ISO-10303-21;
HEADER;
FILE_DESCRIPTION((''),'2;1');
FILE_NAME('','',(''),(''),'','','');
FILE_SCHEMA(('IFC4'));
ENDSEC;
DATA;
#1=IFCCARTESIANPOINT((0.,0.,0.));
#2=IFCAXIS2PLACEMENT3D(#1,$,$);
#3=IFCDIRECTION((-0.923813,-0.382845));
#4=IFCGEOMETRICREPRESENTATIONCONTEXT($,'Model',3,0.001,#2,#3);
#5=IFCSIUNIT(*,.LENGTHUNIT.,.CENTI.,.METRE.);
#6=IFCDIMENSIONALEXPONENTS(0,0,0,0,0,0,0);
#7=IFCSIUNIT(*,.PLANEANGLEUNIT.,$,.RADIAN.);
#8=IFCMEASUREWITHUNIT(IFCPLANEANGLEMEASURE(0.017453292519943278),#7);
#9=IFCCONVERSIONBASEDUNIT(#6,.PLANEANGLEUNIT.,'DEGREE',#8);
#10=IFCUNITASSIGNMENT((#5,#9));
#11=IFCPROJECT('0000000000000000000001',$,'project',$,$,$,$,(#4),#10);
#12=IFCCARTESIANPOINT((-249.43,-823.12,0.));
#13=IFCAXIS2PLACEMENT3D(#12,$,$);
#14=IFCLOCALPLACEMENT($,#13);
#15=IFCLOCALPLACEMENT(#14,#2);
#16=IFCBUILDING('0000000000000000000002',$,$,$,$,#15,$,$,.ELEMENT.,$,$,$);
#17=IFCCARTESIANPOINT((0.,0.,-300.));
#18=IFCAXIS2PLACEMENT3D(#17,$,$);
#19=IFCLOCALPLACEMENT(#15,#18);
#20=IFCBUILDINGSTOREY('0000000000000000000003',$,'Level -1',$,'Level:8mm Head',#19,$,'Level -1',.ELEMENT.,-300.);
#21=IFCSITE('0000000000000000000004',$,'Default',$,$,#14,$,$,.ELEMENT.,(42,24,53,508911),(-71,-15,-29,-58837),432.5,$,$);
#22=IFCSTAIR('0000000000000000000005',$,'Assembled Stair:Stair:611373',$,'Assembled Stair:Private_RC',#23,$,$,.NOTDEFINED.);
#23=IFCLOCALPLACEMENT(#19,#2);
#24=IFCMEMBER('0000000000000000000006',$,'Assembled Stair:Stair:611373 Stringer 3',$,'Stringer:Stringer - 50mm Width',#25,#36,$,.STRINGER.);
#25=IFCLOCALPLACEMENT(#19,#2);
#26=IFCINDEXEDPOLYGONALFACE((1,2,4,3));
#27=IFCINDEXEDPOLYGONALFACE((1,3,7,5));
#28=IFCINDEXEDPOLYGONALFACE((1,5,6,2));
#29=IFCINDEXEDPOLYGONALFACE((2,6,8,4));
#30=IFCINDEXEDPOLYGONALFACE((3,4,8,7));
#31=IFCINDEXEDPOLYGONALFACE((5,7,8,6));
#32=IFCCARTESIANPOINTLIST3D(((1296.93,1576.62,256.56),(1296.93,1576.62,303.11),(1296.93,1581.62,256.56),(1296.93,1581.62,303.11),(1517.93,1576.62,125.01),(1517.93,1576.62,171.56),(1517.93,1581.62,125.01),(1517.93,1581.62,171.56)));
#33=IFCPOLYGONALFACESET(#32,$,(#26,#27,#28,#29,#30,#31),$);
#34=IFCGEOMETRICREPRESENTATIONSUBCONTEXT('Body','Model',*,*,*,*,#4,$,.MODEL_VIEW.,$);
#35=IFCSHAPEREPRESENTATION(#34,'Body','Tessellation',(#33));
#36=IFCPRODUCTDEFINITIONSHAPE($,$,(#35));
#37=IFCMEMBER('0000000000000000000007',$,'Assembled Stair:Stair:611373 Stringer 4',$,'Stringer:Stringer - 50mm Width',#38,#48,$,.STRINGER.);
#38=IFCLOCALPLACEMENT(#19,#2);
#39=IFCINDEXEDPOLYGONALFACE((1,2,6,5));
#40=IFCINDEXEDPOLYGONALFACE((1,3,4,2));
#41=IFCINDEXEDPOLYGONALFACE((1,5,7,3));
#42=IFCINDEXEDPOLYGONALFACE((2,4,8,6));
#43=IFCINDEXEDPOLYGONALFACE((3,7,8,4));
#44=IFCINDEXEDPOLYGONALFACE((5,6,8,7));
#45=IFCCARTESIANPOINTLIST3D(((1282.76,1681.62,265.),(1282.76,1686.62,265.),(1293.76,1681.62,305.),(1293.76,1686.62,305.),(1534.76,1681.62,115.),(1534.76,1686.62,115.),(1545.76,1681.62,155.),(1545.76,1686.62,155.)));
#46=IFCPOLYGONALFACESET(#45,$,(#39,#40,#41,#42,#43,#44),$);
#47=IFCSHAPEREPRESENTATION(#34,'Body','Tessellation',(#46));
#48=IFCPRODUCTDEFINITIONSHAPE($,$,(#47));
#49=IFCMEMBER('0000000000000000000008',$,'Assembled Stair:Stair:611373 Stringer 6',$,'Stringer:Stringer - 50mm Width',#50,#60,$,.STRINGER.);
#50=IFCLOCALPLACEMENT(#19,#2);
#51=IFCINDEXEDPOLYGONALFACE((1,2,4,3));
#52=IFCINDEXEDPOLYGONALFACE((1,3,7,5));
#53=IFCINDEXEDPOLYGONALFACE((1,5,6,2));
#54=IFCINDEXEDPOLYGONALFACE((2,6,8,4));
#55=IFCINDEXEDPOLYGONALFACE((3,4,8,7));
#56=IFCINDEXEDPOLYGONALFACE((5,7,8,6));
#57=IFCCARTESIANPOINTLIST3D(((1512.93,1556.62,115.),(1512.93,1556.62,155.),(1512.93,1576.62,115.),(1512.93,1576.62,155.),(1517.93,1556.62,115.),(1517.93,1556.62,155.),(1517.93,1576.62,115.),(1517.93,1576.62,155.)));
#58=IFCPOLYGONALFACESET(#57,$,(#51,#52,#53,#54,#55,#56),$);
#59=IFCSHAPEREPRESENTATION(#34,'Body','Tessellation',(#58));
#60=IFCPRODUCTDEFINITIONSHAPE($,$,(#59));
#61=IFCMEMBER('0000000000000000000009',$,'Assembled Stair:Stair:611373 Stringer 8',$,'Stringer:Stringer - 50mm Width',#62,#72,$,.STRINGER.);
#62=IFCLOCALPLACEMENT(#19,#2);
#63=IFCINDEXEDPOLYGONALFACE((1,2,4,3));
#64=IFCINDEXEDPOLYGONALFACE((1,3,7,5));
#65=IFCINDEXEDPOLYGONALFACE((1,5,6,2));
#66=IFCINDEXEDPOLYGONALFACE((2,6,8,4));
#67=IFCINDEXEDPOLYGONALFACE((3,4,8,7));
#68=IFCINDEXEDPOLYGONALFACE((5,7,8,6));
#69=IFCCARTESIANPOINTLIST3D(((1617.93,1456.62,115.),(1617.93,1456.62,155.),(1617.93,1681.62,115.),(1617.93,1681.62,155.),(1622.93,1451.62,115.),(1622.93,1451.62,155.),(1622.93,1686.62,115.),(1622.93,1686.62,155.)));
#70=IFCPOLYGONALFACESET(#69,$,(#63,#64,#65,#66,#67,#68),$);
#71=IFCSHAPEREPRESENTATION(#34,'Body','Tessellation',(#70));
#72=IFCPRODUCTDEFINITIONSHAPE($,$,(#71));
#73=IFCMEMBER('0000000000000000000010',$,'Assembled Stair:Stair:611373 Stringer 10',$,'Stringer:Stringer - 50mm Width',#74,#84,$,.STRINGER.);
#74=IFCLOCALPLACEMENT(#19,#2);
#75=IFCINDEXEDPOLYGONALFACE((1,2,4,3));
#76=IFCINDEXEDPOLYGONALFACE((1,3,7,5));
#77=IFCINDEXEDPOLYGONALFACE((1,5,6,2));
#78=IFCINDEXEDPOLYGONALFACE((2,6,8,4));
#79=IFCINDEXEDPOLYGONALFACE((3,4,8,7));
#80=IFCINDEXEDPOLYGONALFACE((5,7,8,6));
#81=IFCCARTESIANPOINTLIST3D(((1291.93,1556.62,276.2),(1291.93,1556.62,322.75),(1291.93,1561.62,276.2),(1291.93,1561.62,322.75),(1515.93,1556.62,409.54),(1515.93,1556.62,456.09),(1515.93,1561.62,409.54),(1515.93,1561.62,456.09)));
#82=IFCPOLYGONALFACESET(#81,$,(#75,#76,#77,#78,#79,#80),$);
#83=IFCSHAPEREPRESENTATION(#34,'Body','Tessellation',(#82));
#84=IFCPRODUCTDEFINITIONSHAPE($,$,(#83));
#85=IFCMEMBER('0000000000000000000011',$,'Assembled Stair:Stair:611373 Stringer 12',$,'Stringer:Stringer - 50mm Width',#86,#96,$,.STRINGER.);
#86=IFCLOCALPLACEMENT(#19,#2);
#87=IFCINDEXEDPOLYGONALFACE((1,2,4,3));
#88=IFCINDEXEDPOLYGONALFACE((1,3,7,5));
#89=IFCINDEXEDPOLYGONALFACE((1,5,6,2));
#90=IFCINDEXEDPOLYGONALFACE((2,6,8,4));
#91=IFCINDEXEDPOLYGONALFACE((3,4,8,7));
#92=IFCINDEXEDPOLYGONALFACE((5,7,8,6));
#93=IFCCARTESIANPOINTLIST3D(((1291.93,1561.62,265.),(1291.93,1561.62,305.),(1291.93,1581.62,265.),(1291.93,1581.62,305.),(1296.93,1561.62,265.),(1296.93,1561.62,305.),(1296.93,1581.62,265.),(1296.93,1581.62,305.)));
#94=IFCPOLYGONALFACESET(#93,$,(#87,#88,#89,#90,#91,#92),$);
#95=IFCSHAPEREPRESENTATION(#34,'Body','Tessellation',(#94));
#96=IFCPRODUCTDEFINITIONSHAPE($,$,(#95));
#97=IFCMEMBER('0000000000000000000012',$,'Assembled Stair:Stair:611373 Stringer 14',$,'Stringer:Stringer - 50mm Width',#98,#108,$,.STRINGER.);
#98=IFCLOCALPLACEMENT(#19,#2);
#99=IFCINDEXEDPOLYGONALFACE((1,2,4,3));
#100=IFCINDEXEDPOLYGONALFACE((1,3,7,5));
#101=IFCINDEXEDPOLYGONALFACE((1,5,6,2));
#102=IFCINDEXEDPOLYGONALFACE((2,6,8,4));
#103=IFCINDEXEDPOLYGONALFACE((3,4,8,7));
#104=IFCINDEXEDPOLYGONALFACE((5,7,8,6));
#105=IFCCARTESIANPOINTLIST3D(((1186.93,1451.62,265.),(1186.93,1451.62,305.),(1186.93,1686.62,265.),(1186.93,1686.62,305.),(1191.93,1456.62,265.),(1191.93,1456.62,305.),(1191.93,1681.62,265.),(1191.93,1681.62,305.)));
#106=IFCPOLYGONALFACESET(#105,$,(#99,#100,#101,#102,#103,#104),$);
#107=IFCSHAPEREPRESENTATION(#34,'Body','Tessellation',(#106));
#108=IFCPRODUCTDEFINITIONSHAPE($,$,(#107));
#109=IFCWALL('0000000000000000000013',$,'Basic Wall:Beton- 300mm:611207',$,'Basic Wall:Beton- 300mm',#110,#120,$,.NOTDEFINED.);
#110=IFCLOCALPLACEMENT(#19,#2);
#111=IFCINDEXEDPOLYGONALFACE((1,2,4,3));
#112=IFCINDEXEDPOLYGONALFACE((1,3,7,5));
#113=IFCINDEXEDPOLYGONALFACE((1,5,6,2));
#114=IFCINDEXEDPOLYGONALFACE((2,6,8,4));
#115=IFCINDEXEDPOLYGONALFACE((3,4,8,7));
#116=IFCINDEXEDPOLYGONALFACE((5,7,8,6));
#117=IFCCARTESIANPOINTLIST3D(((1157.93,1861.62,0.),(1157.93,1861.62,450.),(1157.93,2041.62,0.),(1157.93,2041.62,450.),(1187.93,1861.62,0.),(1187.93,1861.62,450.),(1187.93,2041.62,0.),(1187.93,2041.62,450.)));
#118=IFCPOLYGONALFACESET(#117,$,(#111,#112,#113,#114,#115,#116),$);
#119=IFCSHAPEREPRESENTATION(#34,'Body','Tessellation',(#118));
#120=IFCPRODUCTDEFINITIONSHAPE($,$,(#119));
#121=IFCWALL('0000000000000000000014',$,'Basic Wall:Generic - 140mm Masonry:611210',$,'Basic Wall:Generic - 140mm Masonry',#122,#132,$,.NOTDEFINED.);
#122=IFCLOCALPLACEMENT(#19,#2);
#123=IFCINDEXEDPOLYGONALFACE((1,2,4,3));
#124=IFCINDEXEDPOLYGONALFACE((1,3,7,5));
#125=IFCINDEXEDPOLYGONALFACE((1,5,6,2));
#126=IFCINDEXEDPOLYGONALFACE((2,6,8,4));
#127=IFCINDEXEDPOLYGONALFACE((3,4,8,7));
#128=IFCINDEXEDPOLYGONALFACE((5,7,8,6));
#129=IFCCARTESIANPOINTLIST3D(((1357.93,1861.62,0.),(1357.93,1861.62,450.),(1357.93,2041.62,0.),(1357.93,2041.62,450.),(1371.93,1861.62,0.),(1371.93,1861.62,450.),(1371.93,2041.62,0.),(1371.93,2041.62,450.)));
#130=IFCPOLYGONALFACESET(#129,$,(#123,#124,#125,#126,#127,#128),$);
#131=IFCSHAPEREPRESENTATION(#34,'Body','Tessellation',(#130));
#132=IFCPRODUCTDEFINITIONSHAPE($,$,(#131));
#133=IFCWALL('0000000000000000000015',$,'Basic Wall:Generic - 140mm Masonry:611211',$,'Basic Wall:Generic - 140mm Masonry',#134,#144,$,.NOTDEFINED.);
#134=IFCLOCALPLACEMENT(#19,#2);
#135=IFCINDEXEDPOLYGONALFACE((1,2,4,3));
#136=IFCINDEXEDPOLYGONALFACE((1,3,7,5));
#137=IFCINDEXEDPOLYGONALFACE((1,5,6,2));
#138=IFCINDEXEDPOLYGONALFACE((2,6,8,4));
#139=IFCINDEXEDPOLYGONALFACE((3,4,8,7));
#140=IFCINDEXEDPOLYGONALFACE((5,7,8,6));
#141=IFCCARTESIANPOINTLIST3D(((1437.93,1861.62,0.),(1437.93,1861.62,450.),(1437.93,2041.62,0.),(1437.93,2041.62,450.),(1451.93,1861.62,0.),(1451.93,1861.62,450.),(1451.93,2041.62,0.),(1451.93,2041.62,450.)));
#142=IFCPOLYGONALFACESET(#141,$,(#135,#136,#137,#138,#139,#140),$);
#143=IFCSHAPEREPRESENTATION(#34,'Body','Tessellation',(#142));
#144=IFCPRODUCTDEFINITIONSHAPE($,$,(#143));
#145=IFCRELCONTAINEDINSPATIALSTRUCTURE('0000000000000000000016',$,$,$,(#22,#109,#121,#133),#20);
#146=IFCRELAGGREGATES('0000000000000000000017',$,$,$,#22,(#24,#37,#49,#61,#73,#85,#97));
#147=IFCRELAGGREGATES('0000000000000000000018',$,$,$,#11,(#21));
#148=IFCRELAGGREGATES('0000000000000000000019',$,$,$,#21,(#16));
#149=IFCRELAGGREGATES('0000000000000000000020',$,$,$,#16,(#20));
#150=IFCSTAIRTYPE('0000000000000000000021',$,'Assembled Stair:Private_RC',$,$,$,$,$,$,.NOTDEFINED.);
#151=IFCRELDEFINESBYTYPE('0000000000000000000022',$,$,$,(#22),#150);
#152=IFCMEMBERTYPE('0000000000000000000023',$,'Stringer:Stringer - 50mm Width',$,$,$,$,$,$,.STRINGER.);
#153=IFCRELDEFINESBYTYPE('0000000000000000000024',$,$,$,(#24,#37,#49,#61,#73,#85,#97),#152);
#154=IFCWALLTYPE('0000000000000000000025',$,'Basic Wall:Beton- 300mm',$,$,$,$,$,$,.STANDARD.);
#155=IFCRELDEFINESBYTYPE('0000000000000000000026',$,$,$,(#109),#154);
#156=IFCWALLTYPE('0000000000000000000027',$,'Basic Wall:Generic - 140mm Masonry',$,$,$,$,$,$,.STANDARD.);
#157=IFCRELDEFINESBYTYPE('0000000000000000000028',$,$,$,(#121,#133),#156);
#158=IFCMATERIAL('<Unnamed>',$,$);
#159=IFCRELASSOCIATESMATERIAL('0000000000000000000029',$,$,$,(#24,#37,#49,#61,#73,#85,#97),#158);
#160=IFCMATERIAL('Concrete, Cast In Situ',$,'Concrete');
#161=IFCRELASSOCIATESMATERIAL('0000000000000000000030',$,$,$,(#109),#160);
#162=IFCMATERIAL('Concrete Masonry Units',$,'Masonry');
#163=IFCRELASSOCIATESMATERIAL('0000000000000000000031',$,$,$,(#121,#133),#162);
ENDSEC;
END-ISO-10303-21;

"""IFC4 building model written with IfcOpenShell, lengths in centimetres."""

from ifc_helpers import new_model, entity, si_unit, converted_unit, direction, frame, origin, place, context, subcontext, project, spatial, indexed_curve, outline, extrude, material, type_object, element, aggregate, save


model = new_model("IFC4")

# Units and contexts
model_context = context("Model", 3, precision=0.001, world=origin(), true_north=direction((-0.923813, -0.382845)))
body_context = subcontext(model_context, "Body", "Model", "MODEL_VIEW")
ifc_project = project(units=[si_unit("LENGTHUNIT", "METRE", prefix="CENTI"), converted_unit("PLANEANGLEUNIT", "DEGREE", entity("IfcPlaneAngleMeasure", 0.017453292519943278), si_unit("PLANEANGLEUNIT", "RADIAN"), dimensions=[0, 0, 0, 0, 0, 0, 0])], contexts=[model_context])

# Site, building, storey
site_placement = place(None, frame((-249.43, -823.12, 0.0)))
site = spatial("IfcSite", under=ifc_project, at=site_placement, Name="Default", CompositionType="ELEMENT", RefLatitude=(42, 24, 53, 508911), RefLongitude=(-71, -15, -29, -58837), RefElevation=432.5)
building_placement = place(site_placement, origin())
building = spatial("IfcBuilding", under=site, at=building_placement, CompositionType="ELEMENT")
storey_placement = place(building_placement, frame((0.0, 0.0, -300.0)))
storey = spatial("IfcBuildingStorey", under=building, at=storey_placement, Name="Level -1", ObjectType="Level:8mm Head", LongName="Level -1", CompositionType="ELEMENT", Elevation=-300.0)

# Stair, members
stair_type = type_object("IfcStairType", Name="Assembled Stair:Private_RC", PredefinedType="NOTDEFINED")
stair_placement = place(storey_placement, origin())
stair = element("IfcStair", 1, at=stair_placement, inside=storey, type_object=stair_type, Name="Assembled Stair:Stair:611373", ObjectType="Assembled Stair:Private_RC", PredefinedType="NOTDEFINED")
ifc_material_1 = material(Name="<Unnamed>")
member_type = type_object("IfcMemberType", Name="Stringer:Stringer - 50mm Width", PredefinedType="STRINGER")
member_1_placement = place(stair_placement, origin())
member_1 = element("IfcMember", 2, at=member_1_placement, type_object=member_type, material=ifc_material_1, Name="Assembled Stair:Stair:611373 Stringer 3", ObjectType="Stringer:Stringer - 50mm Width", PredefinedType="STRINGER", context=body_context, shape_type="SweptSolid", body=[
    extrude(outline(indexed_curve([(-140.5, -20.0), (116.69, -20.0), (140.5, 20.0), (-116.69, 20.0), (-140.5, -20.0)], self_intersect=False)), frame((1407.43, 1576.62, 214.06), z_axis=(0.0, 1.0, 0.0), x_axis=(-0.859293, 0.0, 0.511484)), (0.0, 0.0, 1.0), 5.0),
])
member_2_placement = place(stair_placement, origin())
member_2 = element("IfcMember", 3, at=member_2_placement, type_object=member_type, material=ifc_material_1, Name="Assembled Stair:Stair:611373 Stringer 4", ObjectType="Stringer:Stringer - 50mm Width", PredefinedType="STRINGER", context=body_context, shape_type="SweptSolid", body=[
    extrude(outline(indexed_curve([(-152.13, -20.0), (141.13, -20.0), (152.13, 20.0), (-141.13, 20.0), (-152.13, -20.0)], self_intersect=False)), frame((1414.26, 1681.62, 210.0), z_axis=(0.0, 1.0, 0.0), x_axis=(-0.859293, 0.0, 0.511484)), (0.0, 0.0, 1.0), 5.0),
])
member_3_placement = place(stair_placement, origin())
member_3 = element("IfcMember", 4, at=member_3_placement, type_object=member_type, material=ifc_material_1, Name="Assembled Stair:Stair:611373 Stringer 6", ObjectType="Stringer:Stringer - 50mm Width", PredefinedType="STRINGER", context=body_context, shape_type="SweptSolid", body=[
    extrude(outline(indexed_curve([(-10.0, -2.5), (10.0, -2.5), (10.0, 2.5), (-10.0, 2.5), (-10.0, -2.5)], self_intersect=False)), frame((1515.43, 1566.62, 115.0), z_axis=(0.0, 0.0, 1.0), x_axis=(0.0, -1.0, 0.0)), (0.0, 0.0, 1.0), 40.0),
])
member_4_placement = place(stair_placement, origin())
member_4 = element("IfcMember", 5, at=member_4_placement, type_object=member_type, material=ifc_material_1, Name="Assembled Stair:Stair:611373 Stringer 8", ObjectType="Stringer:Stringer - 50mm Width", PredefinedType="STRINGER", context=body_context, shape_type="SweptSolid", body=[
    extrude(outline(indexed_curve([(-117.5, -2.5), (117.5, -2.5), (112.5, 2.5), (-112.5, 2.5), (-117.5, -2.5)], self_intersect=False)), frame((1620.43, 1569.12, 115.0), z_axis=(0.0, 0.0, 1.0), x_axis=(0.0, 1.0, 0.0)), (0.0, 0.0, 1.0), 40.0),
])
member_5_placement = place(stair_placement, origin())
member_5 = element("IfcMember", 6, at=member_5_placement, type_object=member_type, material=ifc_material_1, Name="Assembled Stair:Stair:611373 Stringer 10", ObjectType="Stringer:Stringer - 50mm Width", PredefinedType="STRINGER", context=body_context, shape_type="SweptSolid", body=[
    extrude(outline(indexed_curve([(-118.43, -20.0), (142.24, -20.0), (118.43, 20.0), (-142.24, 20.0), (-118.43, -20.0)], self_intersect=False)), frame((1403.93, 1556.62, 366.15), z_axis=(0.0, 1.0, 0.0), x_axis=(0.859293, 0.0, 0.511484)), (0.0, 0.0, 1.0), 5.0),
])
member_6_placement = place(stair_placement, origin())
member_6 = element("IfcMember", 7, at=member_6_placement, type_object=member_type, material=ifc_material_1, Name="Assembled Stair:Stair:611373 Stringer 12", ObjectType="Stringer:Stringer - 50mm Width", PredefinedType="STRINGER", context=body_context, shape_type="SweptSolid", body=[
    extrude(outline(indexed_curve([(-10.0, -2.5), (10.0, -2.5), (10.0, 2.5), (-10.0, 2.5), (-10.0, -2.5)], self_intersect=False)), frame((1294.43, 1571.62, 265.0), z_axis=(0.0, 0.0, 1.0), x_axis=(0.0, 1.0, 0.0)), (0.0, 0.0, 1.0), 40.0),
])
member_7_placement = place(stair_placement, origin())
member_7 = element("IfcMember", 8, at=member_7_placement, type_object=member_type, material=ifc_material_1, Name="Assembled Stair:Stair:611373 Stringer 14", ObjectType="Stringer:Stringer - 50mm Width", PredefinedType="STRINGER", context=body_context, shape_type="SweptSolid", body=[
    extrude(outline(indexed_curve([(-117.5, -2.5), (117.5, -2.5), (112.5, 2.5), (-112.5, 2.5), (-117.5, -2.5)], self_intersect=False)), frame((1189.43, 1569.12, 265.0), z_axis=(0.0, 0.0, 1.0), x_axis=(0.0, -1.0, 0.0)), (0.0, 0.0, 1.0), 40.0),
])

# Walls
ifc_material_2 = material(Name="Concrete, Cast In Situ", Category="Concrete")
wall_type_1 = type_object("IfcWallType", Name="Basic Wall:Beton- 300mm", PredefinedType="STANDARD")
wall_1_placement = place(storey_placement, frame((1172.93, 2041.62, 0.0), z_axis=(0.0, 0.0, 1.0), x_axis=(0.0, -1.0, 0.0)))
element("IfcWall", 9, at=wall_1_placement, inside=storey, type_object=wall_type_1, material=ifc_material_2, Name="Basic Wall:Beton- 300mm:611207", ObjectType="Basic Wall:Beton- 300mm", PredefinedType="NOTDEFINED", context=body_context, shape_type="SweptSolid", body=[
    extrude(outline(indexed_curve([(180.0, 15.0), (0.0, 15.0), (0.0, -15.0), (180.0, -15.0), (180.0, 15.0)], self_intersect=False)), origin(), (0.0, 0.0, 1.0), 450.0),
])
ifc_material_3 = material(Name="Concrete Masonry Units", Category="Masonry")
wall_type_2 = type_object("IfcWallType", Name="Basic Wall:Generic - 140mm Masonry", PredefinedType="STANDARD")
wall_2_placement = place(storey_placement, frame((1364.93, 2041.62, 0.0), z_axis=(0.0, 0.0, 1.0), x_axis=(0.0, -1.0, 0.0)))
element("IfcWall", 10, at=wall_2_placement, inside=storey, type_object=wall_type_2, material=ifc_material_3, Name="Basic Wall:Generic - 140mm Masonry:611210", ObjectType="Basic Wall:Generic - 140mm Masonry", PredefinedType="NOTDEFINED", context=body_context, shape_type="SweptSolid", body=[
    extrude(outline(indexed_curve([(180.0, 7.0), (0.0, 7.0), (0.0, -7.0), (180.0, -7.0), (180.0, 7.0)], self_intersect=False)), origin(), (0.0, 0.0, 1.0), 450.0),
])
wall_3_placement = place(storey_placement, frame((1444.93, 2041.62, 0.0), z_axis=(0.0, 0.0, 1.0), x_axis=(0.0, -1.0, 0.0)))
element("IfcWall", 11, at=wall_3_placement, inside=storey, type_object=wall_type_2, material=ifc_material_3, Name="Basic Wall:Generic - 140mm Masonry:611211", ObjectType="Basic Wall:Generic - 140mm Masonry", PredefinedType="NOTDEFINED", context=body_context, shape_type="SweptSolid", body=[
    extrude(outline(indexed_curve([(180.0, 7.0), (0.0, 7.0), (0.0, -7.0), (180.0, -7.0), (180.0, 7.0)], self_intersect=False)), origin(), (0.0, 0.0, 1.0), 450.0),
])

aggregate(stair, [member_1, member_2, member_3, member_4, member_5, member_6, member_7])

save(model, "model.ifc")
